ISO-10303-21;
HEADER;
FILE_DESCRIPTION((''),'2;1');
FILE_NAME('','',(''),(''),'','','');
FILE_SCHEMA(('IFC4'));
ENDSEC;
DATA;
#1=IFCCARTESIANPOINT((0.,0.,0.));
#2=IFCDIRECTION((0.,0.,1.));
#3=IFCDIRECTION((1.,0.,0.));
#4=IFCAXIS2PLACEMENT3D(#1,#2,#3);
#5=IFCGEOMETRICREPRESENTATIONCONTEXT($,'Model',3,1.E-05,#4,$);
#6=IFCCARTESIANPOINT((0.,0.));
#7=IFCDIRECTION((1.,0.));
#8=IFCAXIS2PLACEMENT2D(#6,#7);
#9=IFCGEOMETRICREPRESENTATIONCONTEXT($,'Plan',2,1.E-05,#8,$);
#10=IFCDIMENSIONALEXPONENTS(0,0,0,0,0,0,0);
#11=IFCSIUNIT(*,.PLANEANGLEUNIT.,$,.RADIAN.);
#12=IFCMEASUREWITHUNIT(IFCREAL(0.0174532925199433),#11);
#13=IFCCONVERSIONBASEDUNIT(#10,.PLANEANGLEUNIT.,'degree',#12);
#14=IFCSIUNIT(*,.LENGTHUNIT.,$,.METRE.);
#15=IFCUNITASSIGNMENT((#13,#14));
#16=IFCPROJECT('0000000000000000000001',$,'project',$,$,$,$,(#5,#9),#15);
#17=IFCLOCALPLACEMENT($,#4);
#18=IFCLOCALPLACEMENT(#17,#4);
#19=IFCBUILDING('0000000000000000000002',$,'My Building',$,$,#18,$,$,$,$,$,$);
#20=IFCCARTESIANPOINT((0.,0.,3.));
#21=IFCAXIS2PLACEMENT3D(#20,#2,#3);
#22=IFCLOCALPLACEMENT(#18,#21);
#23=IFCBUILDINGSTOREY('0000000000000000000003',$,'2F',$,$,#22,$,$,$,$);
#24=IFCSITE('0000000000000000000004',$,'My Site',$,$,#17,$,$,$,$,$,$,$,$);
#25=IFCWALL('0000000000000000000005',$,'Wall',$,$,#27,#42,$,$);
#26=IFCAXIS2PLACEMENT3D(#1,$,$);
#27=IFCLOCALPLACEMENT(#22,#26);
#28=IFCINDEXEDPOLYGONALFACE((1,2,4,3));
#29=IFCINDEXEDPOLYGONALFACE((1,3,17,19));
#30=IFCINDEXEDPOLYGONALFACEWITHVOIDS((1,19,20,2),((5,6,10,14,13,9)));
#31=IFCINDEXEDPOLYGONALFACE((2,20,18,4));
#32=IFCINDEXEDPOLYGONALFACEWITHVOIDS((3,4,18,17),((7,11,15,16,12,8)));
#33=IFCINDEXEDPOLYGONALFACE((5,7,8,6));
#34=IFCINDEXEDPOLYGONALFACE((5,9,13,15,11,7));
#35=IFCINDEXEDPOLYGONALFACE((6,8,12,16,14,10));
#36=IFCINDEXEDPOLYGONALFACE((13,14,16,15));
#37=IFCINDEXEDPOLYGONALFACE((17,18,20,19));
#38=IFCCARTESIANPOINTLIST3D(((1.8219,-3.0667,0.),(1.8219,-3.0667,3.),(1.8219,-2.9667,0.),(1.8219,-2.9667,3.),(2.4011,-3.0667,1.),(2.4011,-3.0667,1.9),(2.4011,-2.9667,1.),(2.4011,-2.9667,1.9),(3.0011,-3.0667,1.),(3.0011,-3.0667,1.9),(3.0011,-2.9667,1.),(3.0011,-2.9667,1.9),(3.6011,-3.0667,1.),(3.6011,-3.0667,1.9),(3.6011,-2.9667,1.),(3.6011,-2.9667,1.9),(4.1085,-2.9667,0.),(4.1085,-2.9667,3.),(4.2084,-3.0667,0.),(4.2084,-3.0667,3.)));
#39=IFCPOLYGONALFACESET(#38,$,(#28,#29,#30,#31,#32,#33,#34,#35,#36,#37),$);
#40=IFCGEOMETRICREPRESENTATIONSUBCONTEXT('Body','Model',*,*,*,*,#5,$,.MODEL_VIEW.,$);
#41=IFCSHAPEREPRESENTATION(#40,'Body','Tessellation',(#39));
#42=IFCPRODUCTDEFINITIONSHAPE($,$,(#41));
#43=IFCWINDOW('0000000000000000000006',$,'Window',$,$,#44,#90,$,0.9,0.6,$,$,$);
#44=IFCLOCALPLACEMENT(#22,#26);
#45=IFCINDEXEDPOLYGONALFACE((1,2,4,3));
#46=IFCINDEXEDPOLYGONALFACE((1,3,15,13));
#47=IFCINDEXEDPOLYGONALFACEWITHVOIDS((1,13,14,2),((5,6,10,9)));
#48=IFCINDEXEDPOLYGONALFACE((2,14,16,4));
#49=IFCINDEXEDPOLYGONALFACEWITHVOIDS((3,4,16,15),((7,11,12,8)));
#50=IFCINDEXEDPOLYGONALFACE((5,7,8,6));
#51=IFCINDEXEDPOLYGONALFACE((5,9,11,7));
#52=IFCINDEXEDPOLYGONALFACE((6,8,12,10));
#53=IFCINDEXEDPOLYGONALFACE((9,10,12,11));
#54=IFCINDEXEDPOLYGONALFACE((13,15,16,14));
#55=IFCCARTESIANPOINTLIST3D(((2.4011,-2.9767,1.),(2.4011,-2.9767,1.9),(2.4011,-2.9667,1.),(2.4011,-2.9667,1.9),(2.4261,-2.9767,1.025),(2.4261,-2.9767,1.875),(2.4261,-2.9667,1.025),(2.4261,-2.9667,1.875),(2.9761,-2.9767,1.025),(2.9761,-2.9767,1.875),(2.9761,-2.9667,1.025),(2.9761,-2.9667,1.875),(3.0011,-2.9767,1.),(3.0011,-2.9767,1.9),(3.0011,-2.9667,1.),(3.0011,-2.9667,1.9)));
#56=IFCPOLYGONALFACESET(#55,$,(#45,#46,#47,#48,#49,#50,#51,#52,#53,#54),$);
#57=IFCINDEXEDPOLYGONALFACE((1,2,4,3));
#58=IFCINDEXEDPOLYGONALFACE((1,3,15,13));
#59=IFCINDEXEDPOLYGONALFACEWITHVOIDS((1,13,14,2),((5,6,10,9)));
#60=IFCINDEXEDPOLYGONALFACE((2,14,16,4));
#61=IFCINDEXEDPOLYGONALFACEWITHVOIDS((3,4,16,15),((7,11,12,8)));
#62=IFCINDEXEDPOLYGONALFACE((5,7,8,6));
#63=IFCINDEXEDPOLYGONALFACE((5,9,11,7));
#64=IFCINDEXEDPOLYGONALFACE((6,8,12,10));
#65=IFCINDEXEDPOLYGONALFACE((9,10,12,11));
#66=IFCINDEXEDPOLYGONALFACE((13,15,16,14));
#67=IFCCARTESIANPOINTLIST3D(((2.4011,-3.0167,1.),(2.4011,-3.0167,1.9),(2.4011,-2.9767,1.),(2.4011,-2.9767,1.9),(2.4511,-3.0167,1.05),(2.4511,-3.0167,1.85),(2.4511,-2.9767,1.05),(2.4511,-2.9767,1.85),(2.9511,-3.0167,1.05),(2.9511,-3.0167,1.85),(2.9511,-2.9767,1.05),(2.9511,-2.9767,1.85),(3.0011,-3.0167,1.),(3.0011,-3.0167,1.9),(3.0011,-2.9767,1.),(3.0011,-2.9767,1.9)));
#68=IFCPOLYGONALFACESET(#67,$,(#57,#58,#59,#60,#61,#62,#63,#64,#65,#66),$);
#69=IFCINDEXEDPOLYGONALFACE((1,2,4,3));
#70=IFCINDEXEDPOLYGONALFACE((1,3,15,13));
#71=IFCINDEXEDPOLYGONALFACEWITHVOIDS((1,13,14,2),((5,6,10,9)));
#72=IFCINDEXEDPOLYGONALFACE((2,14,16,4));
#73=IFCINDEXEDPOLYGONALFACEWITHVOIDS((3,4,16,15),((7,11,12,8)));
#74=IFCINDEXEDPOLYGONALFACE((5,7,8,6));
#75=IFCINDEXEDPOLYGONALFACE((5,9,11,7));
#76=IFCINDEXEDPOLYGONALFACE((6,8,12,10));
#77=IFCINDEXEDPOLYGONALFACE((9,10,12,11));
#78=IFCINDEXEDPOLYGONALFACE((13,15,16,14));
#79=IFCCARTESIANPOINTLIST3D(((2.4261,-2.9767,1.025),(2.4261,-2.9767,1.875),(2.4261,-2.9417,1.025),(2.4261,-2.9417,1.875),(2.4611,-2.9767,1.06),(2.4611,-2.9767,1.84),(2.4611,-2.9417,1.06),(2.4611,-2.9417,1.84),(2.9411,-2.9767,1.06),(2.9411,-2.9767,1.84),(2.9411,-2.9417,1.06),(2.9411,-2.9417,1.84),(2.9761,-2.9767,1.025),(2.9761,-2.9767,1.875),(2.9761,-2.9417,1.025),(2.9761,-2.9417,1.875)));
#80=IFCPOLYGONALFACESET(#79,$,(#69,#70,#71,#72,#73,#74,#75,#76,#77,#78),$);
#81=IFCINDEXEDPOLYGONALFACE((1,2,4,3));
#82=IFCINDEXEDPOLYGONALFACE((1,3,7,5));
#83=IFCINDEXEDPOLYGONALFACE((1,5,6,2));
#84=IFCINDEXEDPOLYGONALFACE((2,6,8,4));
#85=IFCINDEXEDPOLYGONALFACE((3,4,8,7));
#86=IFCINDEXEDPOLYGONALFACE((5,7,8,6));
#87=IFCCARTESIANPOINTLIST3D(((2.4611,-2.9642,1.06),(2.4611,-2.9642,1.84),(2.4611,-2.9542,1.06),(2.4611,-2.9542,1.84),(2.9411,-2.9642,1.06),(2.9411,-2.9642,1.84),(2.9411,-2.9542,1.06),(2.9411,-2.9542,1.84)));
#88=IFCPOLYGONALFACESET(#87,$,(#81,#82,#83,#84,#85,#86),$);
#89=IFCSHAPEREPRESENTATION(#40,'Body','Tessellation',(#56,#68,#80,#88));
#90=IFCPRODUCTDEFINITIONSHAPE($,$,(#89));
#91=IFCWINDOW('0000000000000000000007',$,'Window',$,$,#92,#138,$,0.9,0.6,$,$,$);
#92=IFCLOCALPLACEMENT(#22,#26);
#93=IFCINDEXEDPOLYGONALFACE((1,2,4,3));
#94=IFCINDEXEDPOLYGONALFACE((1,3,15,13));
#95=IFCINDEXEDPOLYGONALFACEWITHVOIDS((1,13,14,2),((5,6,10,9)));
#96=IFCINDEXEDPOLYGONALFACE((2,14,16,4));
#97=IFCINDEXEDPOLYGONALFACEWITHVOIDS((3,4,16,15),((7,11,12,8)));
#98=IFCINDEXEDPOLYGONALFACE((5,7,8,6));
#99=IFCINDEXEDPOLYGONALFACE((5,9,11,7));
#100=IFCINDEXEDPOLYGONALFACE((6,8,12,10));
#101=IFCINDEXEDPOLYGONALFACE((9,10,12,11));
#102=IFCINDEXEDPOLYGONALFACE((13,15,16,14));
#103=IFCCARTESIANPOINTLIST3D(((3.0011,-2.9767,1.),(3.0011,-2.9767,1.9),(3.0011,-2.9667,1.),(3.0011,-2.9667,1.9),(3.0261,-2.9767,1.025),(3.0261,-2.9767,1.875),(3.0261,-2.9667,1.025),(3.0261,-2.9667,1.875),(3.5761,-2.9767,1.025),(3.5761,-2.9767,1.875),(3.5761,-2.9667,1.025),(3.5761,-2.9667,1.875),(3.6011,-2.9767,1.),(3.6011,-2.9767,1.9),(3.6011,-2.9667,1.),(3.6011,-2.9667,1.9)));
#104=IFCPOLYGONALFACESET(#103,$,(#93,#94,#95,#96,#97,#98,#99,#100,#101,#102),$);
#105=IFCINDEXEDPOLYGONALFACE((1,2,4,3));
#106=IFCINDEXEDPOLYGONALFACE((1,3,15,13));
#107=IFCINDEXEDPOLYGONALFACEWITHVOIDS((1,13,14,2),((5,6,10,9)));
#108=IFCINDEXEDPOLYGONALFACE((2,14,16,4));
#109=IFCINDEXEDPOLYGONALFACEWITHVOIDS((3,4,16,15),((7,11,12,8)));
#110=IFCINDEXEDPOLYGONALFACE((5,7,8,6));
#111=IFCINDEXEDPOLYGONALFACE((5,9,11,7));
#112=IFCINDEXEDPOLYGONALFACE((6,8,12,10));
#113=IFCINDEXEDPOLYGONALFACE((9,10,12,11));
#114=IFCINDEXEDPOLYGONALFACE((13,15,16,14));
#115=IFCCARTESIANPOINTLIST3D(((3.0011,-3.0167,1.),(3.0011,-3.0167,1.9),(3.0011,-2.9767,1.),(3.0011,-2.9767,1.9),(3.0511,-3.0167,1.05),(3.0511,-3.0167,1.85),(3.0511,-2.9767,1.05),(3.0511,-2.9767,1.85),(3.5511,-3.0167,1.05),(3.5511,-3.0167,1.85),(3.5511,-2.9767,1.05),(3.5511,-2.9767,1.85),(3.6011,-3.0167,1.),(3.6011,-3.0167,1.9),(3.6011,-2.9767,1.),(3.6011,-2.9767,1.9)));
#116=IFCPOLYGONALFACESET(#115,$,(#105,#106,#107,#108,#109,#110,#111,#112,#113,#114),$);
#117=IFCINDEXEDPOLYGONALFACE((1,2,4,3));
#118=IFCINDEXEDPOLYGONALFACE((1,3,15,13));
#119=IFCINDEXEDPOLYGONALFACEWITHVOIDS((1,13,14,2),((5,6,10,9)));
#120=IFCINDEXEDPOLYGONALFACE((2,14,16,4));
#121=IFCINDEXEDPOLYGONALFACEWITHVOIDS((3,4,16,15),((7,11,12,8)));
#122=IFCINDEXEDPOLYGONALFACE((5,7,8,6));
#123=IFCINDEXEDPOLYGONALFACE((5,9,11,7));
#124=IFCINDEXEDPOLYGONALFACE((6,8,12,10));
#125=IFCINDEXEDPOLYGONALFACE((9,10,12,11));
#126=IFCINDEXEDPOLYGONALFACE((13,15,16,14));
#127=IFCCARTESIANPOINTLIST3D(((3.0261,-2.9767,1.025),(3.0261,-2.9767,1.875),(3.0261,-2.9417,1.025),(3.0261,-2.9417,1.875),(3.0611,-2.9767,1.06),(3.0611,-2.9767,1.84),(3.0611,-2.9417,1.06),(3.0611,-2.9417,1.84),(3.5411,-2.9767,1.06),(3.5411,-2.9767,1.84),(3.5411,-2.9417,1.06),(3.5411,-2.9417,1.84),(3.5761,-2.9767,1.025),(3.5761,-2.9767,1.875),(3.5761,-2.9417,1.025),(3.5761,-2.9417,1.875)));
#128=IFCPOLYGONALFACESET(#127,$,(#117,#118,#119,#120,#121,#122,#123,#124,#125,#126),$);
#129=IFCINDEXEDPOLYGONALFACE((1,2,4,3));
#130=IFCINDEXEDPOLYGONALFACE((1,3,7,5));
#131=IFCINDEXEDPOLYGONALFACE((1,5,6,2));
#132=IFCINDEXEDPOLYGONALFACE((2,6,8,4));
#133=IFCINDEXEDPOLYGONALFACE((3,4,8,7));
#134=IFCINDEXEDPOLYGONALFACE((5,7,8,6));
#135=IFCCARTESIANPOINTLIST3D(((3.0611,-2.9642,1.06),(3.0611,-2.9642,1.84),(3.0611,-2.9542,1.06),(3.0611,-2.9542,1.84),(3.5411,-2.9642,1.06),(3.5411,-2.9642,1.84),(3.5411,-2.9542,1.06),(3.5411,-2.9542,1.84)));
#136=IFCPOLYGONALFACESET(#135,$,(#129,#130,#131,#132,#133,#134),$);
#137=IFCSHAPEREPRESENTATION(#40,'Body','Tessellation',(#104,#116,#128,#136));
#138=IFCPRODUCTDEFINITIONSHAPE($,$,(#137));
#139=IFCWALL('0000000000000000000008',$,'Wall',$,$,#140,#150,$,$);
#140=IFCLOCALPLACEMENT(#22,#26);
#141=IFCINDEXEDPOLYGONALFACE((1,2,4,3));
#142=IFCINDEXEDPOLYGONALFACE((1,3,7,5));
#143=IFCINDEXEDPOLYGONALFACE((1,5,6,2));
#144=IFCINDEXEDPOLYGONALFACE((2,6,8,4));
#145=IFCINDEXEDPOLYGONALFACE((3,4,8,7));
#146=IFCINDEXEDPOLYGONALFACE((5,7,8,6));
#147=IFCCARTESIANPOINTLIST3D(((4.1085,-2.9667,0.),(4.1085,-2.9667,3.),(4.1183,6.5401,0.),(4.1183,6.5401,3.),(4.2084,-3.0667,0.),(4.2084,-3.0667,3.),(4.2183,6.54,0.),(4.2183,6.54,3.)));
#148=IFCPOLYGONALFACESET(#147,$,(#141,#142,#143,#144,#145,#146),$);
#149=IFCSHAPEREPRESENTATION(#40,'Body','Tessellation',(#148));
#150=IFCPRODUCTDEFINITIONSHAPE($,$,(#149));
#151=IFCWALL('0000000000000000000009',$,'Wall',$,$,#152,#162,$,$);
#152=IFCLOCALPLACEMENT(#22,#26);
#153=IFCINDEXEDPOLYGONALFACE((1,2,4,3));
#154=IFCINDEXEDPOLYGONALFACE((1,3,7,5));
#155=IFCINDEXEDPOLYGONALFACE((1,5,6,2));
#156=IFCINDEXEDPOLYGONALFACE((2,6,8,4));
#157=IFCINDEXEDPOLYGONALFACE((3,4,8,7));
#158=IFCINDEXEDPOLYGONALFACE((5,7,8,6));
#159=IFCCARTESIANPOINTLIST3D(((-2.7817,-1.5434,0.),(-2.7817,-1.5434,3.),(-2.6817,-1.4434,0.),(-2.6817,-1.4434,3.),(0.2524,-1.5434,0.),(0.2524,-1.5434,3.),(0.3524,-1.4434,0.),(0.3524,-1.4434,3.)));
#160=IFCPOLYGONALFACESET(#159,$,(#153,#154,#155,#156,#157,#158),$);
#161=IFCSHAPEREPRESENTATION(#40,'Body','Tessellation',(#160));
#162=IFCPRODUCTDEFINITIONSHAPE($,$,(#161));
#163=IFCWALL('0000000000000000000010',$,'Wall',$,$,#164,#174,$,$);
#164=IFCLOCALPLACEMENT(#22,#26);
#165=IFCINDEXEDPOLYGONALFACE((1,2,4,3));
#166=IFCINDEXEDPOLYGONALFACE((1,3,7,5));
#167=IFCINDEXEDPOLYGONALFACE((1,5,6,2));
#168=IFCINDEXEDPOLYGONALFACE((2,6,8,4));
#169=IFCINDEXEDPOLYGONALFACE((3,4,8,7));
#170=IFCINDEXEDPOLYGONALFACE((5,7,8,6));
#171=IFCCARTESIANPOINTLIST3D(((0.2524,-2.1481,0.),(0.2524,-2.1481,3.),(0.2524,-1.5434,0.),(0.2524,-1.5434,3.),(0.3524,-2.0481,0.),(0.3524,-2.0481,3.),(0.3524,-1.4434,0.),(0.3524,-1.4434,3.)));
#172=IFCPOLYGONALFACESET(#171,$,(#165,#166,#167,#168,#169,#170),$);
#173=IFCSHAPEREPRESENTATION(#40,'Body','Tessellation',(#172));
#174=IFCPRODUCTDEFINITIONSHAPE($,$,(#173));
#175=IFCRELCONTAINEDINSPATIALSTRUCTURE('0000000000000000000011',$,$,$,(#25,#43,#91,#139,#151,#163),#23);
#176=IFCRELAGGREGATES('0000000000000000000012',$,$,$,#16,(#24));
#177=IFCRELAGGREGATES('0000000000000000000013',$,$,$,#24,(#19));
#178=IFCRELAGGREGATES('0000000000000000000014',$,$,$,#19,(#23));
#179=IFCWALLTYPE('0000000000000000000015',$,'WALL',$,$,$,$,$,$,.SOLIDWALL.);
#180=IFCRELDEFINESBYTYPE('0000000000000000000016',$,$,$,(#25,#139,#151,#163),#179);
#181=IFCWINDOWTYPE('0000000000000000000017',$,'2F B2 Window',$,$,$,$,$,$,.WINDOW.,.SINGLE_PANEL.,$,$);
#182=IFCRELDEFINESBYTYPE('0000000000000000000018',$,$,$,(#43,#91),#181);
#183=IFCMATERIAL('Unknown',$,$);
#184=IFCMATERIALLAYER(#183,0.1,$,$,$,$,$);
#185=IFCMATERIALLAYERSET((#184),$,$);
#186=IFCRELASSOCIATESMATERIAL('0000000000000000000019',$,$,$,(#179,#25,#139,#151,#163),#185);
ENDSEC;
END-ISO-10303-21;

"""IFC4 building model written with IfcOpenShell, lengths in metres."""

from ifc_helpers import new_model, entity, si_unit, converted_unit, frame, origin_with_axes, origin_2d_with_axis, place, context, subcontext, project, spatial, line, indexed_curve, outline, extrude, shape, source, transform, mapped, material, layer, layer_set, layer_usage, type_object, type_shapes, element, fill, save


model = new_model("IFC4")

# Units and contexts
model_context = context("Model", 3, precision=1e-05, world=origin_with_axes())
plan_context = context("Plan", 2, precision=1e-05, world=origin_2d_with_axis())
body_context_1 = subcontext(model_context, "Body", "Model", "MODEL_VIEW")
body_context_2 = subcontext(plan_context, "Body", "Plan", "PLAN_VIEW")
ifc_project = project(units=[converted_unit("PLANEANGLEUNIT", "degree", entity("IfcReal", 0.0174532925199433), si_unit("PLANEANGLEUNIT", "RADIAN"), dimensions=[0, 0, 0, 0, 0, 0, 0]), si_unit("LENGTHUNIT", "METRE")], contexts=[model_context, plan_context])

# Site, building, storey
site_placement = place(None, origin_with_axes())
site = spatial("IfcSite", under=ifc_project, at=site_placement, Name="My Site")
building_placement = place(site_placement, origin_with_axes())
building = spatial("IfcBuilding", under=site, at=building_placement, Name="My Building")
storey_placement = place(building_placement, frame((0.0, 0.0, 3.0), z_axis=(0.0, 0.0, 1.0), x_axis=(1.0, 0.0, 0.0)))
storey = spatial("IfcBuildingStorey", under=building, at=storey_placement, Name="2F")

# Shared definitions
ifc_material = material(Name="Unknown")

# Shared definitions
ifc_layer_1 = layer(ifc_material, 0.1)
ifc_layer_set_1 = layer_set([ifc_layer_1])
wall_type = type_object("IfcWallType", Name="WALL", PredefinedType="SOLIDWALL", material=ifc_layer_set_1)

# Wall, openings, windows
ifc_layer_usage_1 = layer_usage(ifc_layer_set_1, "AXIS2", "POSITIVE", 0.0)
wall_1_placement = place(storey_placement, frame((1.8219, -3.0667, 0.0), z_axis=(0.0, 0.0, 1.0), x_axis=(1.0, 0.000007, 0.0)))
wall_1 = element("IfcWall", 1, at=wall_1_placement, inside=storey, type_object=wall_type, material=ifc_layer_usage_1, Name="Wall", context=body_context_1, shape_type="SweptSolid", body=[
    extrude(outline(indexed_curve([(0.0, 0.0), (0.0, 0.1), (2.2866, 0.1), (2.3865, 0.0)], segments=[line(1, 2, 3, 4, 1)])), origin_with_axes(), (0.0, 0.0, 1.0), 3.0),
])
shared_shape_1 = source(origin_with_axes(), body_context_1, "Body", "SweptSolid", [
    extrude(outline(indexed_curve([(0.0, 0.0), (0.6, 0.0), (0.6, 0.9), (0.0, 0.9)], segments=[line(1, 2, 3, 4, 1)])), frame((0.0, -0.6, 0.0), z_axis=(0.0, -1.0, 0.0), x_axis=(1.0, 0.0, 0.0)), (0.0, 0.0, -1.0), 1.2),
])
opening_1_placement = place(wall_1_placement, frame((0.5792, 0.0, 1.0), z_axis=(0.0, 0.0, 1.0), x_axis=(1.0, 0.0, 0.0)))
opening_1 = element("IfcOpeningElement", 2, at=opening_1_placement, cuts=wall_1, PredefinedType="OPENING", context=body_context_1, shape_type="MappedRepresentation", body=[
    mapped(shared_shape_1, transform((0.0, 0.0, 0.0), x_axis=(1.0, 0.0, 0.0), y_axis=(0.0, 1.0, 0.0), z_axis=(0.0, 0.0, 1.0), scale=1.0)),
])
opening_2_placement = place(wall_1_placement, frame((1.1792, 0.0, 1.0), z_axis=(0.0, 0.0, 1.0), x_axis=(1.0, 0.0, 0.0)))
opening_2 = element("IfcOpeningElement", 3, at=opening_2_placement, cuts=wall_1, PredefinedType="OPENING", context=body_context_1, shape_type="MappedRepresentation", body=[
    mapped(shared_shape_1, transform((0.0, 0.0, 0.0), x_axis=(1.0, 0.0, 0.0), y_axis=(0.0, 1.0, 0.0), z_axis=(0.0, 0.0, 1.0), scale=1.0)),
])
window_type_1 = type_object("IfcWindowType", Name="2F B2 Window", PartitioningType="SINGLE_PANEL", PredefinedType="WINDOW")
shared_shape_2 = source(origin_with_axes(), body_context_1, "Body", "SweptSolid", [
    extrude(outline(indexed_curve([(0.0, 0.0), (0.6, 0.0), (0.6, 0.9), (0.0, 0.9)], segments=[line(1, 2, 3, 4, 1)]), holes=[indexed_curve([(0.025, 0.025), (0.575, 0.025), (0.575, 0.875), (0.025, 0.875)], segments=[line(1, 2, 3, 4, 1)])]), frame((0.0, 0.09, 0.0), z_axis=(0.0, -1.0, 0.0), x_axis=(1.0, 0.0, 0.0)), (0.0, 0.0, -1.0), 0.01),
    extrude(outline(indexed_curve([(0.0, 0.0), (0.6, 0.0), (0.6, 0.9), (0.0, 0.9)], segments=[line(1, 2, 3, 4, 1)]), holes=[indexed_curve([(0.05, 0.05), (0.55, 0.05), (0.55, 0.85), (0.05, 0.85)], segments=[line(1, 2, 3, 4, 1)])]), frame((0.0, 0.05, 0.0), z_axis=(0.0, -1.0, 0.0), x_axis=(1.0, 0.0, 0.0)), (0.0, 0.0, -1.0), 0.04),
    extrude(outline(indexed_curve([(0.0, 0.0), (0.55, 0.0), (0.55, 0.85), (0.0, 0.85)], segments=[line(1, 2, 3, 4, 1)]), holes=[indexed_curve([(0.035, 0.035), (0.515, 0.035), (0.515, 0.815), (0.035, 0.815)], segments=[line(1, 2, 3, 4, 1)])]), frame((0.025, 0.09, 0.025), z_axis=(0.0, -1.0, 0.0), x_axis=(1.0, 0.0, 0.0)), (0.0, 0.0, -1.0), 0.035),
    extrude(outline(indexed_curve([(0.035, 0.035), (0.515, 0.035), (0.515, 0.815), (0.035, 0.815)], segments=[line(1, 2, 3, 4, 1)])), frame((0.025, 0.1025, 0.025), z_axis=(0.0, -1.0, 0.0), x_axis=(1.0, 0.0, 0.0)), (0.0, 0.0, -1.0), 0.01),
])
shared_shape_3 = source(origin_with_axes(), body_context_2, "Body", "Curve2D", [
    entity("IfcIndexedPolyCurve", entity("IfcCartesianPointList2D", [[0.05, 0.05], [0.55, 0.05]])),
    entity("IfcIndexedPolyCurve", entity("IfcCartesianPointList2D", [[0.0, 0.1], [0.025, 0.1], [0.025, 0.09], [0.05, 0.09], [0.05, 0.05], [0.0, 0.05]]), [entity("IfcLineIndex", [1, 2, 3, 4, 5, 6, 1])]),
    entity("IfcIndexedPolyCurve", entity("IfcCartesianPointList2D", [[0.6, 0.1], [0.575, 0.1], [0.575, 0.09], [0.55, 0.09], [0.55, 0.05], [0.6, 0.05]]), [entity("IfcLineIndex", [1, 2, 3, 4, 5, 6, 1])]),
    entity("IfcIndexedPolyCurve", entity("IfcCartesianPointList2D", [[0.025, 0.09], [0.06, 0.09], [0.06, 0.125], [0.025, 0.125]]), [entity("IfcLineIndex", [1, 2, 3, 4, 1])]),
    entity("IfcIndexedPolyCurve", entity("IfcCartesianPointList2D", [[0.575, 0.09], [0.54, 0.09], [0.54, 0.125], [0.575, 0.125]]), [entity("IfcLineIndex", [1, 2, 3, 4, 1])]),
    entity("IfcIndexedPolyCurve", entity("IfcCartesianPointList2D", [[0.06, 0.09], [0.54, 0.09]])),
    entity("IfcIndexedPolyCurve", entity("IfcCartesianPointList2D", [[0.06, 0.125], [0.54, 0.125]])),
    entity("IfcIndexedPolyCurve", entity("IfcCartesianPointList2D", [[0.06, 0.1075], [0.54, 0.1075]])),
])
type_shapes(window_type_1, [shared_shape_2, shared_shape_3])
window_1_placement = place(opening_1_placement, origin_with_axes())
window_1 = element("IfcWindow", 4, at=window_1_placement, inside=storey, type_object=window_type_1, Name="Window", OverallHeight=0.9, OverallWidth=0.6, shapes=[
    shape(body_context_1, "Body", "MappedRepresentation", [mapped(shared_shape_2, transform((0.0, 0.0, 0.0), x_axis=(1.0, 0.0, 0.0), y_axis=(0.0, 1.0, 0.0), z_axis=(0.0, 0.0, 1.0), scale=1.0))]),
    shape(body_context_2, "Body", "MappedRepresentation", [mapped(shared_shape_3, transform((0.0, 0.0, 0.0), x_axis=(1.0, 0.0, 0.0), y_axis=(0.0, 1.0, 0.0), z_axis=(0.0, 0.0, 1.0), scale=1.0))]),
])
fill(opening_1, window_1)
window_2_placement = place(opening_2_placement, frame((0.0, 0.0, 0.0), z_axis=(0.0, 0.0, 1.0), x_axis=(1.0, 0.0, 0.0)))
window_2 = element("IfcWindow", 5, at=window_2_placement, inside=storey, type_object=window_type_1, Name="Window", OverallHeight=0.9, OverallWidth=0.6, shapes=[
    shape(body_context_1, "Body", "MappedRepresentation", [mapped(shared_shape_2, transform((0.0, 0.0, 0.0), x_axis=(1.0, 0.0, 0.0), y_axis=(0.0, 1.0, 0.0), z_axis=(0.0, 0.0, 1.0), scale=1.0))]),
    shape(body_context_2, "Body", "MappedRepresentation", [mapped(shared_shape_3, transform((0.0, 0.0, 0.0), x_axis=(1.0, 0.0, 0.0), y_axis=(0.0, 1.0, 0.0), z_axis=(0.0, 0.0, 1.0), scale=1.0))]),
])
fill(opening_2, window_2)

# Walls
ifc_layer_usage_2 = layer_usage(ifc_layer_set_1, "AXIS2", "POSITIVE", 0.0)
wall_2_placement = place(storey_placement, frame((4.2084, -3.0667, 0.0), z_axis=(0.0, 0.0, 1.0), x_axis=(0.001035, 0.999999, 0.0)))
element("IfcWall", 6, at=wall_2_placement, inside=storey, type_object=wall_type, material=ifc_layer_usage_2, Name="Wall", context=body_context_1, shape_type="SweptSolid", body=[
    extrude(outline(indexed_curve([(0.0, 0.0), (0.0999, 0.1), (9.6067, 0.1), (9.6067, 0.0)], segments=[line(1, 2, 3, 4, 1)])), origin_with_axes(), (0.0, 0.0, 1.0), 3.0),
])
ifc_layer_usage_3 = layer_usage(ifc_layer_set_1, "AXIS2", "POSITIVE", 0.0)
wall_3_placement = place(storey_placement, frame((-2.7817, -1.5434, 0.0), z_axis=(0.0, 0.0, 1.0), x_axis=(1.0, 0.0, 0.0)))
element("IfcWall", 7, at=wall_3_placement, inside=storey, type_object=wall_type, material=ifc_layer_usage_3, Name="Wall", context=body_context_1, shape_type="SweptSolid", body=[
    extrude(outline(indexed_curve([(0.0, 0.0), (0.1, 0.1), (3.1341, 0.1), (3.0341, 0.0)], segments=[line(1, 2, 3, 4, 1)])), origin_with_axes(), (0.0, 0.0, 1.0), 3.0),
])
ifc_layer_usage_4 = layer_usage(ifc_layer_set_1, "AXIS2", "POSITIVE", 0.0)
wall_4_placement = place(storey_placement, frame((0.2524, -1.5434, 0.0), z_axis=(0.0, 0.0, 1.0), x_axis=(0.0, -1.0, 0.0)))
element("IfcWall", 8, at=wall_4_placement, inside=storey, type_object=wall_type, material=ifc_layer_usage_4, Name="Wall", context=body_context_1, shape_type="SweptSolid", body=[
    extrude(outline(indexed_curve([(0.0, 0.0), (-0.1, 0.1), (0.5047, 0.1), (0.6047, 0.0)], segments=[line(1, 2, 3, 4, 1)])), origin_with_axes(), (0.0, 0.0, 1.0), 3.0),
])

save(model, "model.ifc")
